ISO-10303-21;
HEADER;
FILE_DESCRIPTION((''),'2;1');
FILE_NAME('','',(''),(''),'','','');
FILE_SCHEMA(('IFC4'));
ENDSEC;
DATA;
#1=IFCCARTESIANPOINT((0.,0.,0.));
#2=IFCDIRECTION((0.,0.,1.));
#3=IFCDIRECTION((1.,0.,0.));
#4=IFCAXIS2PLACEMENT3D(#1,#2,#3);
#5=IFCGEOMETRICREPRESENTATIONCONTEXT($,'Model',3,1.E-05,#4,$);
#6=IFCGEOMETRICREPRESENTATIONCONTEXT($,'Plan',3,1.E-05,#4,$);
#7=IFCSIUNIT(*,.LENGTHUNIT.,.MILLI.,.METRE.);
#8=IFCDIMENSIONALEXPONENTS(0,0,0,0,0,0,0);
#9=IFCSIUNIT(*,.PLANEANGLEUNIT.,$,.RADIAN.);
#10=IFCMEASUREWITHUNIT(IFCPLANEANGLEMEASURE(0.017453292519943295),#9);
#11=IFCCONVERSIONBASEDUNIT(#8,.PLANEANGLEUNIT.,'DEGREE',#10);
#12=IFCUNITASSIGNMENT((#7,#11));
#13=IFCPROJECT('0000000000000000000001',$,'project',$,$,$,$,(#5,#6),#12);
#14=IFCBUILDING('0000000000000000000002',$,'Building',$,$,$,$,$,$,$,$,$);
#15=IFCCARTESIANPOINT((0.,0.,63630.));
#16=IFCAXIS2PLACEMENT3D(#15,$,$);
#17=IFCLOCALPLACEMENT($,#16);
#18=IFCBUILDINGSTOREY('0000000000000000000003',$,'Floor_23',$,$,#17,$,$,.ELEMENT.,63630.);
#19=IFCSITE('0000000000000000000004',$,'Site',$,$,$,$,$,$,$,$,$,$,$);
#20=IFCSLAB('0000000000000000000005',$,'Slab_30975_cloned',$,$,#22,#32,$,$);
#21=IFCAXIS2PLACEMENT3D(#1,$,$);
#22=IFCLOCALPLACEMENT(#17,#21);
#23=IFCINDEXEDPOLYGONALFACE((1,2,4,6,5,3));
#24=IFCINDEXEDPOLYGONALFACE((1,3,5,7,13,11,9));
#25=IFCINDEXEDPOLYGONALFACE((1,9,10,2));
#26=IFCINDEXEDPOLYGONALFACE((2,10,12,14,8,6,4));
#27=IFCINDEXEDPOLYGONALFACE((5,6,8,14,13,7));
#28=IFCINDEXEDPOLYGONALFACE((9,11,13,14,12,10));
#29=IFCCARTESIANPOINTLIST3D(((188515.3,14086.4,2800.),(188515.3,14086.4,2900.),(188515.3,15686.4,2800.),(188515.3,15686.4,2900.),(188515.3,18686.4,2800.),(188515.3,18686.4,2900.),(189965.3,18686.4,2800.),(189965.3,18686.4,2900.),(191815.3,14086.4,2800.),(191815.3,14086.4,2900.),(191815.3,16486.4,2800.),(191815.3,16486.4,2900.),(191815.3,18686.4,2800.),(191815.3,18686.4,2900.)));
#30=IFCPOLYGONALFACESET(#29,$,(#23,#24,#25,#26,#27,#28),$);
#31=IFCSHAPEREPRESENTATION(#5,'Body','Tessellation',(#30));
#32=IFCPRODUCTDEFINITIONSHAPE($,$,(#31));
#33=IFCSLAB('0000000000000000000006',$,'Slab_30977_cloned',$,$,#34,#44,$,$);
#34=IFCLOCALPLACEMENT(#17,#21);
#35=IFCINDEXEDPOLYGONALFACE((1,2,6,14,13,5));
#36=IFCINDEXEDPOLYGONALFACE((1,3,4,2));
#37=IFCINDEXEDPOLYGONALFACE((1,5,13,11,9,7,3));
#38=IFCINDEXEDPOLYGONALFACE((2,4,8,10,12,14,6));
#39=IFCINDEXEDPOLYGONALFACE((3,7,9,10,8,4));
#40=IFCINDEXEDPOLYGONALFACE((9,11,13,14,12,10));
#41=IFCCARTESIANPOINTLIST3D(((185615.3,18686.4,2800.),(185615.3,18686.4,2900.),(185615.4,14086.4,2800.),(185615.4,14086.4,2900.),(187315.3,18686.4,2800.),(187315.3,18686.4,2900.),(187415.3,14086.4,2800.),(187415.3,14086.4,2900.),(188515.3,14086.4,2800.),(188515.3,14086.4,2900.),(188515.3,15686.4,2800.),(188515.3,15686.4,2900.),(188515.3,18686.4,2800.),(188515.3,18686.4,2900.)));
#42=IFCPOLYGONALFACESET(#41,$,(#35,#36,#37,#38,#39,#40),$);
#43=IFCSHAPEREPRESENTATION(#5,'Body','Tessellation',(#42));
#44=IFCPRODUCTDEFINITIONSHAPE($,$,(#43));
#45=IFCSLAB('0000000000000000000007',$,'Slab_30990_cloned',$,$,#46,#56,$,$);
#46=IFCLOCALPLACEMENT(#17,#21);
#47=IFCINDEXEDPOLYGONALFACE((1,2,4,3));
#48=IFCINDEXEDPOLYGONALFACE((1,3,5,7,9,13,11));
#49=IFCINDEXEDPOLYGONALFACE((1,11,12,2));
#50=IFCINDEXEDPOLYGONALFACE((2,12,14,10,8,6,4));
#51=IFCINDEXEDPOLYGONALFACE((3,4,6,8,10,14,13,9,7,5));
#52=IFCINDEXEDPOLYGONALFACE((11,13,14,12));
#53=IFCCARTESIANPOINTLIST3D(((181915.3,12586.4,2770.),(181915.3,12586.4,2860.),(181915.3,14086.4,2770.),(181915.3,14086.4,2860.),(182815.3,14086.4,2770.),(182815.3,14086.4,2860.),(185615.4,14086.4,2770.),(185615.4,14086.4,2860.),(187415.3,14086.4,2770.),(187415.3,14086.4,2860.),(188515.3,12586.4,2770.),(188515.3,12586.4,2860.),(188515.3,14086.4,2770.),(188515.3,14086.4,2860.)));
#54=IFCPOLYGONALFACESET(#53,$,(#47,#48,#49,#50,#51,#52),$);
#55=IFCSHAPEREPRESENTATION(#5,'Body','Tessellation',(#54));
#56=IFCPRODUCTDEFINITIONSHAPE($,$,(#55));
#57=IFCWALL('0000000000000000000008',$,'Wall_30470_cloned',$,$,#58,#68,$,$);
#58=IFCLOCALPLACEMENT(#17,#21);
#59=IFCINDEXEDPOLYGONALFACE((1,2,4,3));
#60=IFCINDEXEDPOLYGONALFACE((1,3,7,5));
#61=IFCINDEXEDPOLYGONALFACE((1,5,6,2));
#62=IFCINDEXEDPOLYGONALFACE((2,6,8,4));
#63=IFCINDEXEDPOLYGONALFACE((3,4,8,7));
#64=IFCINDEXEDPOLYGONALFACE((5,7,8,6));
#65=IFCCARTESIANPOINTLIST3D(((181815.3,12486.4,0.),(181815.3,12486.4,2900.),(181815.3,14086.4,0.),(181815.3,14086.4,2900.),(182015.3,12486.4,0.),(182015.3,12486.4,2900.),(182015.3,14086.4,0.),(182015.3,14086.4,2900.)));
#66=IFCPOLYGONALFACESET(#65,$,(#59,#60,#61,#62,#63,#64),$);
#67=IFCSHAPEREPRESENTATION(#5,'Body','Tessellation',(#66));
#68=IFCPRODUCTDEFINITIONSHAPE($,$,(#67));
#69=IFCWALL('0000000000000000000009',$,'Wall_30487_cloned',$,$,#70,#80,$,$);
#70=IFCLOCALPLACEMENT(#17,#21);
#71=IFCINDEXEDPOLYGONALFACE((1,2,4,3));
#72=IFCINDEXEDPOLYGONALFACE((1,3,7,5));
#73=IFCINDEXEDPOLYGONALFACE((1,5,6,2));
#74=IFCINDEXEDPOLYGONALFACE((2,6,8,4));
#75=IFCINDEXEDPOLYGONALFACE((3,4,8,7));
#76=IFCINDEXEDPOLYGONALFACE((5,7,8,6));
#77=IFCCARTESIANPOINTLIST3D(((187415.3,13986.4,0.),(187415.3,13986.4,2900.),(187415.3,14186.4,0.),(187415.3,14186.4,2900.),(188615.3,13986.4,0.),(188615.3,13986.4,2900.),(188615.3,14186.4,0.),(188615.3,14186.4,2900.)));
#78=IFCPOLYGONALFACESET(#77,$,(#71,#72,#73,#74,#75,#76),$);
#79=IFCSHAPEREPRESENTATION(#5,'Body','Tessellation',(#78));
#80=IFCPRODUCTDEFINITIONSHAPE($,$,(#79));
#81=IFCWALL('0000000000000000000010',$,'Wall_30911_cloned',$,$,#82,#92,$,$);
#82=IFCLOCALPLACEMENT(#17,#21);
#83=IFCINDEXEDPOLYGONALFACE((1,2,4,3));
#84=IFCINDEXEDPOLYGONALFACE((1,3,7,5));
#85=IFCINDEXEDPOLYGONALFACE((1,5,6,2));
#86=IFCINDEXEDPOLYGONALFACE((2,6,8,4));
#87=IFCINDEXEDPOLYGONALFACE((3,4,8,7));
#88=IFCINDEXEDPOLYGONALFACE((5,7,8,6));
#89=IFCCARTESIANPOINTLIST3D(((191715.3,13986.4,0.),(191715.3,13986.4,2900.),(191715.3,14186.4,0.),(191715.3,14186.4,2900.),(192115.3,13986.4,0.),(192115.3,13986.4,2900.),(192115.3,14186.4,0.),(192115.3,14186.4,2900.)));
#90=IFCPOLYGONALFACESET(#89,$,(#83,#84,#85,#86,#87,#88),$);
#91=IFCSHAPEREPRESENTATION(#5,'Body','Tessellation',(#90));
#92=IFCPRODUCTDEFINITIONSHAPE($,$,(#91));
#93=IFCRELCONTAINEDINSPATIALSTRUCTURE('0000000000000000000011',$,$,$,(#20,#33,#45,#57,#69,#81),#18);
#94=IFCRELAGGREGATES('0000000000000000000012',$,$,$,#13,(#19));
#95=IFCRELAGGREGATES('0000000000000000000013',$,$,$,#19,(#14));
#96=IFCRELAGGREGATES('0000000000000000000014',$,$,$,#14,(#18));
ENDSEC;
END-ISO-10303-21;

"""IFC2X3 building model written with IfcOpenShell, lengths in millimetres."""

from ifc_helpers import new_model, entity, si_unit, converted_unit, frame, origin_with_axes, origin_2d, place, context, project, spatial, polyline, rectangle, outline, extrude, source, transform, mapped, element, save


model = new_model("IFC2X3")

# Units and contexts
model_context = context("Model", 3, precision=1e-05, world=origin_with_axes())
plan_context = context("Plan", 3, precision=1e-05, world=origin_with_axes())
ifc_project = project(units=[si_unit("LENGTHUNIT", "METRE", prefix="MILLI"), converted_unit("PLANEANGLEUNIT", "DEGREE", entity("IfcPlaneAngleMeasure", 0.017453292519943295), si_unit("PLANEANGLEUNIT", "RADIAN"), dimensions=[0, 0, 0, 0, 0, 0, 0])], contexts=[model_context, plan_context])

# Site, building, storey
site = spatial("IfcSite", under=ifc_project, Name="Site")
building = spatial("IfcBuilding", under=site, Name="Building")
storey_placement = place(None, frame((0.0, 0.0, 63630.0)))
storey = spatial("IfcBuildingStorey", under=building, at=storey_placement, Name="Floor_23", CompositionType="ELEMENT", Elevation=63630.0)

# Slabs
shared_shape_1 = source(origin_with_axes(), model_context, "Body", "SweptSolid", [
    extrude(outline(polyline([(0.0, 0.0), (3000.0, 0.0), (4600.0, 0.0), (4600.0, 3300.0), (2200.0, 3300.0), (0.0, 3300.0), (0.0, 1450.0)])), origin_with_axes(), (0.0, 0.0, 1.0), 100.0),
])
slab_1_placement = place(storey_placement, frame((188515.3, 18686.4, 2800.0), z_axis=(0.0, 0.0, 1.0), x_axis=(-0.027, -2999.994, 0.0)))
element("IfcSlab", 1, at=slab_1_placement, inside=storey, Name="Slab_30975_cloned", context=model_context, shape_type="MappedRepresentation", body=[
    mapped(shared_shape_1, transform((0.0, 0.0, 0.0), x_axis=(1.0, 0.0, 0.0), y_axis=(0.0, 1.0, 0.0), z_axis=(0.0, 0.0, 1.0), scale=1.0)),
])
shared_shape_2 = source(origin_with_axes(), model_context, "Body", "SweptSolid", [
    extrude(outline(polyline([(0.0, 0.0), (4600.0, 0.0), (4600.0, 1799.9), (4600.0, 2900.0), (3000.0, 2900.0), (0.0, 2900.0), (0.0, 1700.0)])), origin_with_axes(), (0.0, 0.0, 1.0), 100.0),
])
slab_2_placement = place(storey_placement, frame((185615.3, 18686.4, 2800.0), z_axis=(0.0, 0.0, 1.0), x_axis=(0.055, -4600.0, 0.0)))
element("IfcSlab", 2, at=slab_2_placement, inside=storey, Name="Slab_30977_cloned", context=model_context, shape_type="MappedRepresentation", body=[
    mapped(shared_shape_2, transform((0.0, 0.0, 0.0), x_axis=(1.0, 0.0, 0.0), y_axis=(0.0, 1.0, 0.0), z_axis=(0.0, 0.0, 1.0), scale=1.0)),
])
shared_shape_3 = source(origin_with_axes(), model_context, "Body", "SweptSolid", [
    extrude(outline(polyline([(0.0, 0.0), (1500.0, 0.0), (1500.0, 6600.0), (0.0, 6600.0), (0.0, 5500.0), (0.0, 3700.1), (0.0, 900.0)])), origin_with_axes(), (0.0, 0.0, 1.0), 90.0),
])
slab_3_placement = place(storey_placement, frame((181915.3, 14086.4, 2770.0), z_axis=(0.0, 0.0, 1.0), x_axis=(0.0, -1500.0, 0.0)))
element("IfcSlab", 3, at=slab_3_placement, inside=storey, Name="Slab_30990_cloned", context=model_context, shape_type="MappedRepresentation", body=[
    mapped(shared_shape_3, transform((0.0, 0.0, 0.0), x_axis=(1.0, 0.0, 0.0), y_axis=(0.0, 1.0, 0.0), z_axis=(0.0, 0.0, 1.0), scale=1.0)),
])

# Walls
shared_shape_4 = source(origin_with_axes(), model_context, "Body", "SweptSolid", [
    extrude(rectangle(XDim=1600.0, YDim=200.0, at=origin_2d()), origin_with_axes(), (0.0, 0.0, 1.0), 2900.0),
])
wall_1_placement = place(storey_placement, frame((181915.3, 13286.4, 0.0), z_axis=(0.0, 0.0, 1.0), x_axis=(0.0, 1600.000004, 0.0)))
element("IfcWall", 4, at=wall_1_placement, inside=storey, Name="Wall_30470_cloned", context=model_context, shape_type="MappedRepresentation", body=[
    mapped(shared_shape_4, transform((0.0, 0.0, 0.0), x_axis=(1.0, 0.0, 0.0), y_axis=(0.0, 1.0, 0.0), z_axis=(0.0, 0.0, 1.0), scale=1.0)),
])
shared_shape_5 = source(origin_with_axes(), model_context, "Body", "SweptSolid", [
    extrude(rectangle(XDim=1200.0, YDim=200.0, at=origin_2d()), origin_with_axes(), (0.0, 0.0, 1.0), 2900.0),
])
wall_2_placement = place(storey_placement, frame((188015.3, 14086.4, 0.0), z_axis=(0.0, 0.0, 1.0), x_axis=(1200.020798, 0.0, 0.0)))
element("IfcWall", 5, at=wall_2_placement, inside=storey, Name="Wall_30487_cloned", context=model_context, shape_type="MappedRepresentation", body=[
    mapped(shared_shape_5, transform((0.0, 0.0, 0.0), x_axis=(1.0, 0.0, 0.0), y_axis=(0.0, 1.0, 0.0), z_axis=(0.0, 0.0, 1.0), scale=1.0)),
])
shared_shape_6 = source(origin_with_axes(), model_context, "Body", "SweptSolid", [
    extrude(rectangle(XDim=400.0, YDim=200.0, at=origin_2d()), origin_with_axes(), (0.0, 0.0, 1.0), 2900.0),
])
wall_3_placement = place(storey_placement, frame((191915.3, 14086.4, 0.0), z_axis=(0.0, 0.0, 1.0), x_axis=(400.0, 0.0, 0.0)))
element("IfcWall", 6, at=wall_3_placement, inside=storey, Name="Wall_30911_cloned", context=model_context, shape_type="MappedRepresentation", body=[
    mapped(shared_shape_6, transform((0.0, 0.0, 0.0), x_axis=(1.0, 0.0, 0.0), y_axis=(0.0, 1.0, 0.0), z_axis=(0.0, 0.0, 1.0), scale=1.0)),
])

save(model, "model.ifc")
